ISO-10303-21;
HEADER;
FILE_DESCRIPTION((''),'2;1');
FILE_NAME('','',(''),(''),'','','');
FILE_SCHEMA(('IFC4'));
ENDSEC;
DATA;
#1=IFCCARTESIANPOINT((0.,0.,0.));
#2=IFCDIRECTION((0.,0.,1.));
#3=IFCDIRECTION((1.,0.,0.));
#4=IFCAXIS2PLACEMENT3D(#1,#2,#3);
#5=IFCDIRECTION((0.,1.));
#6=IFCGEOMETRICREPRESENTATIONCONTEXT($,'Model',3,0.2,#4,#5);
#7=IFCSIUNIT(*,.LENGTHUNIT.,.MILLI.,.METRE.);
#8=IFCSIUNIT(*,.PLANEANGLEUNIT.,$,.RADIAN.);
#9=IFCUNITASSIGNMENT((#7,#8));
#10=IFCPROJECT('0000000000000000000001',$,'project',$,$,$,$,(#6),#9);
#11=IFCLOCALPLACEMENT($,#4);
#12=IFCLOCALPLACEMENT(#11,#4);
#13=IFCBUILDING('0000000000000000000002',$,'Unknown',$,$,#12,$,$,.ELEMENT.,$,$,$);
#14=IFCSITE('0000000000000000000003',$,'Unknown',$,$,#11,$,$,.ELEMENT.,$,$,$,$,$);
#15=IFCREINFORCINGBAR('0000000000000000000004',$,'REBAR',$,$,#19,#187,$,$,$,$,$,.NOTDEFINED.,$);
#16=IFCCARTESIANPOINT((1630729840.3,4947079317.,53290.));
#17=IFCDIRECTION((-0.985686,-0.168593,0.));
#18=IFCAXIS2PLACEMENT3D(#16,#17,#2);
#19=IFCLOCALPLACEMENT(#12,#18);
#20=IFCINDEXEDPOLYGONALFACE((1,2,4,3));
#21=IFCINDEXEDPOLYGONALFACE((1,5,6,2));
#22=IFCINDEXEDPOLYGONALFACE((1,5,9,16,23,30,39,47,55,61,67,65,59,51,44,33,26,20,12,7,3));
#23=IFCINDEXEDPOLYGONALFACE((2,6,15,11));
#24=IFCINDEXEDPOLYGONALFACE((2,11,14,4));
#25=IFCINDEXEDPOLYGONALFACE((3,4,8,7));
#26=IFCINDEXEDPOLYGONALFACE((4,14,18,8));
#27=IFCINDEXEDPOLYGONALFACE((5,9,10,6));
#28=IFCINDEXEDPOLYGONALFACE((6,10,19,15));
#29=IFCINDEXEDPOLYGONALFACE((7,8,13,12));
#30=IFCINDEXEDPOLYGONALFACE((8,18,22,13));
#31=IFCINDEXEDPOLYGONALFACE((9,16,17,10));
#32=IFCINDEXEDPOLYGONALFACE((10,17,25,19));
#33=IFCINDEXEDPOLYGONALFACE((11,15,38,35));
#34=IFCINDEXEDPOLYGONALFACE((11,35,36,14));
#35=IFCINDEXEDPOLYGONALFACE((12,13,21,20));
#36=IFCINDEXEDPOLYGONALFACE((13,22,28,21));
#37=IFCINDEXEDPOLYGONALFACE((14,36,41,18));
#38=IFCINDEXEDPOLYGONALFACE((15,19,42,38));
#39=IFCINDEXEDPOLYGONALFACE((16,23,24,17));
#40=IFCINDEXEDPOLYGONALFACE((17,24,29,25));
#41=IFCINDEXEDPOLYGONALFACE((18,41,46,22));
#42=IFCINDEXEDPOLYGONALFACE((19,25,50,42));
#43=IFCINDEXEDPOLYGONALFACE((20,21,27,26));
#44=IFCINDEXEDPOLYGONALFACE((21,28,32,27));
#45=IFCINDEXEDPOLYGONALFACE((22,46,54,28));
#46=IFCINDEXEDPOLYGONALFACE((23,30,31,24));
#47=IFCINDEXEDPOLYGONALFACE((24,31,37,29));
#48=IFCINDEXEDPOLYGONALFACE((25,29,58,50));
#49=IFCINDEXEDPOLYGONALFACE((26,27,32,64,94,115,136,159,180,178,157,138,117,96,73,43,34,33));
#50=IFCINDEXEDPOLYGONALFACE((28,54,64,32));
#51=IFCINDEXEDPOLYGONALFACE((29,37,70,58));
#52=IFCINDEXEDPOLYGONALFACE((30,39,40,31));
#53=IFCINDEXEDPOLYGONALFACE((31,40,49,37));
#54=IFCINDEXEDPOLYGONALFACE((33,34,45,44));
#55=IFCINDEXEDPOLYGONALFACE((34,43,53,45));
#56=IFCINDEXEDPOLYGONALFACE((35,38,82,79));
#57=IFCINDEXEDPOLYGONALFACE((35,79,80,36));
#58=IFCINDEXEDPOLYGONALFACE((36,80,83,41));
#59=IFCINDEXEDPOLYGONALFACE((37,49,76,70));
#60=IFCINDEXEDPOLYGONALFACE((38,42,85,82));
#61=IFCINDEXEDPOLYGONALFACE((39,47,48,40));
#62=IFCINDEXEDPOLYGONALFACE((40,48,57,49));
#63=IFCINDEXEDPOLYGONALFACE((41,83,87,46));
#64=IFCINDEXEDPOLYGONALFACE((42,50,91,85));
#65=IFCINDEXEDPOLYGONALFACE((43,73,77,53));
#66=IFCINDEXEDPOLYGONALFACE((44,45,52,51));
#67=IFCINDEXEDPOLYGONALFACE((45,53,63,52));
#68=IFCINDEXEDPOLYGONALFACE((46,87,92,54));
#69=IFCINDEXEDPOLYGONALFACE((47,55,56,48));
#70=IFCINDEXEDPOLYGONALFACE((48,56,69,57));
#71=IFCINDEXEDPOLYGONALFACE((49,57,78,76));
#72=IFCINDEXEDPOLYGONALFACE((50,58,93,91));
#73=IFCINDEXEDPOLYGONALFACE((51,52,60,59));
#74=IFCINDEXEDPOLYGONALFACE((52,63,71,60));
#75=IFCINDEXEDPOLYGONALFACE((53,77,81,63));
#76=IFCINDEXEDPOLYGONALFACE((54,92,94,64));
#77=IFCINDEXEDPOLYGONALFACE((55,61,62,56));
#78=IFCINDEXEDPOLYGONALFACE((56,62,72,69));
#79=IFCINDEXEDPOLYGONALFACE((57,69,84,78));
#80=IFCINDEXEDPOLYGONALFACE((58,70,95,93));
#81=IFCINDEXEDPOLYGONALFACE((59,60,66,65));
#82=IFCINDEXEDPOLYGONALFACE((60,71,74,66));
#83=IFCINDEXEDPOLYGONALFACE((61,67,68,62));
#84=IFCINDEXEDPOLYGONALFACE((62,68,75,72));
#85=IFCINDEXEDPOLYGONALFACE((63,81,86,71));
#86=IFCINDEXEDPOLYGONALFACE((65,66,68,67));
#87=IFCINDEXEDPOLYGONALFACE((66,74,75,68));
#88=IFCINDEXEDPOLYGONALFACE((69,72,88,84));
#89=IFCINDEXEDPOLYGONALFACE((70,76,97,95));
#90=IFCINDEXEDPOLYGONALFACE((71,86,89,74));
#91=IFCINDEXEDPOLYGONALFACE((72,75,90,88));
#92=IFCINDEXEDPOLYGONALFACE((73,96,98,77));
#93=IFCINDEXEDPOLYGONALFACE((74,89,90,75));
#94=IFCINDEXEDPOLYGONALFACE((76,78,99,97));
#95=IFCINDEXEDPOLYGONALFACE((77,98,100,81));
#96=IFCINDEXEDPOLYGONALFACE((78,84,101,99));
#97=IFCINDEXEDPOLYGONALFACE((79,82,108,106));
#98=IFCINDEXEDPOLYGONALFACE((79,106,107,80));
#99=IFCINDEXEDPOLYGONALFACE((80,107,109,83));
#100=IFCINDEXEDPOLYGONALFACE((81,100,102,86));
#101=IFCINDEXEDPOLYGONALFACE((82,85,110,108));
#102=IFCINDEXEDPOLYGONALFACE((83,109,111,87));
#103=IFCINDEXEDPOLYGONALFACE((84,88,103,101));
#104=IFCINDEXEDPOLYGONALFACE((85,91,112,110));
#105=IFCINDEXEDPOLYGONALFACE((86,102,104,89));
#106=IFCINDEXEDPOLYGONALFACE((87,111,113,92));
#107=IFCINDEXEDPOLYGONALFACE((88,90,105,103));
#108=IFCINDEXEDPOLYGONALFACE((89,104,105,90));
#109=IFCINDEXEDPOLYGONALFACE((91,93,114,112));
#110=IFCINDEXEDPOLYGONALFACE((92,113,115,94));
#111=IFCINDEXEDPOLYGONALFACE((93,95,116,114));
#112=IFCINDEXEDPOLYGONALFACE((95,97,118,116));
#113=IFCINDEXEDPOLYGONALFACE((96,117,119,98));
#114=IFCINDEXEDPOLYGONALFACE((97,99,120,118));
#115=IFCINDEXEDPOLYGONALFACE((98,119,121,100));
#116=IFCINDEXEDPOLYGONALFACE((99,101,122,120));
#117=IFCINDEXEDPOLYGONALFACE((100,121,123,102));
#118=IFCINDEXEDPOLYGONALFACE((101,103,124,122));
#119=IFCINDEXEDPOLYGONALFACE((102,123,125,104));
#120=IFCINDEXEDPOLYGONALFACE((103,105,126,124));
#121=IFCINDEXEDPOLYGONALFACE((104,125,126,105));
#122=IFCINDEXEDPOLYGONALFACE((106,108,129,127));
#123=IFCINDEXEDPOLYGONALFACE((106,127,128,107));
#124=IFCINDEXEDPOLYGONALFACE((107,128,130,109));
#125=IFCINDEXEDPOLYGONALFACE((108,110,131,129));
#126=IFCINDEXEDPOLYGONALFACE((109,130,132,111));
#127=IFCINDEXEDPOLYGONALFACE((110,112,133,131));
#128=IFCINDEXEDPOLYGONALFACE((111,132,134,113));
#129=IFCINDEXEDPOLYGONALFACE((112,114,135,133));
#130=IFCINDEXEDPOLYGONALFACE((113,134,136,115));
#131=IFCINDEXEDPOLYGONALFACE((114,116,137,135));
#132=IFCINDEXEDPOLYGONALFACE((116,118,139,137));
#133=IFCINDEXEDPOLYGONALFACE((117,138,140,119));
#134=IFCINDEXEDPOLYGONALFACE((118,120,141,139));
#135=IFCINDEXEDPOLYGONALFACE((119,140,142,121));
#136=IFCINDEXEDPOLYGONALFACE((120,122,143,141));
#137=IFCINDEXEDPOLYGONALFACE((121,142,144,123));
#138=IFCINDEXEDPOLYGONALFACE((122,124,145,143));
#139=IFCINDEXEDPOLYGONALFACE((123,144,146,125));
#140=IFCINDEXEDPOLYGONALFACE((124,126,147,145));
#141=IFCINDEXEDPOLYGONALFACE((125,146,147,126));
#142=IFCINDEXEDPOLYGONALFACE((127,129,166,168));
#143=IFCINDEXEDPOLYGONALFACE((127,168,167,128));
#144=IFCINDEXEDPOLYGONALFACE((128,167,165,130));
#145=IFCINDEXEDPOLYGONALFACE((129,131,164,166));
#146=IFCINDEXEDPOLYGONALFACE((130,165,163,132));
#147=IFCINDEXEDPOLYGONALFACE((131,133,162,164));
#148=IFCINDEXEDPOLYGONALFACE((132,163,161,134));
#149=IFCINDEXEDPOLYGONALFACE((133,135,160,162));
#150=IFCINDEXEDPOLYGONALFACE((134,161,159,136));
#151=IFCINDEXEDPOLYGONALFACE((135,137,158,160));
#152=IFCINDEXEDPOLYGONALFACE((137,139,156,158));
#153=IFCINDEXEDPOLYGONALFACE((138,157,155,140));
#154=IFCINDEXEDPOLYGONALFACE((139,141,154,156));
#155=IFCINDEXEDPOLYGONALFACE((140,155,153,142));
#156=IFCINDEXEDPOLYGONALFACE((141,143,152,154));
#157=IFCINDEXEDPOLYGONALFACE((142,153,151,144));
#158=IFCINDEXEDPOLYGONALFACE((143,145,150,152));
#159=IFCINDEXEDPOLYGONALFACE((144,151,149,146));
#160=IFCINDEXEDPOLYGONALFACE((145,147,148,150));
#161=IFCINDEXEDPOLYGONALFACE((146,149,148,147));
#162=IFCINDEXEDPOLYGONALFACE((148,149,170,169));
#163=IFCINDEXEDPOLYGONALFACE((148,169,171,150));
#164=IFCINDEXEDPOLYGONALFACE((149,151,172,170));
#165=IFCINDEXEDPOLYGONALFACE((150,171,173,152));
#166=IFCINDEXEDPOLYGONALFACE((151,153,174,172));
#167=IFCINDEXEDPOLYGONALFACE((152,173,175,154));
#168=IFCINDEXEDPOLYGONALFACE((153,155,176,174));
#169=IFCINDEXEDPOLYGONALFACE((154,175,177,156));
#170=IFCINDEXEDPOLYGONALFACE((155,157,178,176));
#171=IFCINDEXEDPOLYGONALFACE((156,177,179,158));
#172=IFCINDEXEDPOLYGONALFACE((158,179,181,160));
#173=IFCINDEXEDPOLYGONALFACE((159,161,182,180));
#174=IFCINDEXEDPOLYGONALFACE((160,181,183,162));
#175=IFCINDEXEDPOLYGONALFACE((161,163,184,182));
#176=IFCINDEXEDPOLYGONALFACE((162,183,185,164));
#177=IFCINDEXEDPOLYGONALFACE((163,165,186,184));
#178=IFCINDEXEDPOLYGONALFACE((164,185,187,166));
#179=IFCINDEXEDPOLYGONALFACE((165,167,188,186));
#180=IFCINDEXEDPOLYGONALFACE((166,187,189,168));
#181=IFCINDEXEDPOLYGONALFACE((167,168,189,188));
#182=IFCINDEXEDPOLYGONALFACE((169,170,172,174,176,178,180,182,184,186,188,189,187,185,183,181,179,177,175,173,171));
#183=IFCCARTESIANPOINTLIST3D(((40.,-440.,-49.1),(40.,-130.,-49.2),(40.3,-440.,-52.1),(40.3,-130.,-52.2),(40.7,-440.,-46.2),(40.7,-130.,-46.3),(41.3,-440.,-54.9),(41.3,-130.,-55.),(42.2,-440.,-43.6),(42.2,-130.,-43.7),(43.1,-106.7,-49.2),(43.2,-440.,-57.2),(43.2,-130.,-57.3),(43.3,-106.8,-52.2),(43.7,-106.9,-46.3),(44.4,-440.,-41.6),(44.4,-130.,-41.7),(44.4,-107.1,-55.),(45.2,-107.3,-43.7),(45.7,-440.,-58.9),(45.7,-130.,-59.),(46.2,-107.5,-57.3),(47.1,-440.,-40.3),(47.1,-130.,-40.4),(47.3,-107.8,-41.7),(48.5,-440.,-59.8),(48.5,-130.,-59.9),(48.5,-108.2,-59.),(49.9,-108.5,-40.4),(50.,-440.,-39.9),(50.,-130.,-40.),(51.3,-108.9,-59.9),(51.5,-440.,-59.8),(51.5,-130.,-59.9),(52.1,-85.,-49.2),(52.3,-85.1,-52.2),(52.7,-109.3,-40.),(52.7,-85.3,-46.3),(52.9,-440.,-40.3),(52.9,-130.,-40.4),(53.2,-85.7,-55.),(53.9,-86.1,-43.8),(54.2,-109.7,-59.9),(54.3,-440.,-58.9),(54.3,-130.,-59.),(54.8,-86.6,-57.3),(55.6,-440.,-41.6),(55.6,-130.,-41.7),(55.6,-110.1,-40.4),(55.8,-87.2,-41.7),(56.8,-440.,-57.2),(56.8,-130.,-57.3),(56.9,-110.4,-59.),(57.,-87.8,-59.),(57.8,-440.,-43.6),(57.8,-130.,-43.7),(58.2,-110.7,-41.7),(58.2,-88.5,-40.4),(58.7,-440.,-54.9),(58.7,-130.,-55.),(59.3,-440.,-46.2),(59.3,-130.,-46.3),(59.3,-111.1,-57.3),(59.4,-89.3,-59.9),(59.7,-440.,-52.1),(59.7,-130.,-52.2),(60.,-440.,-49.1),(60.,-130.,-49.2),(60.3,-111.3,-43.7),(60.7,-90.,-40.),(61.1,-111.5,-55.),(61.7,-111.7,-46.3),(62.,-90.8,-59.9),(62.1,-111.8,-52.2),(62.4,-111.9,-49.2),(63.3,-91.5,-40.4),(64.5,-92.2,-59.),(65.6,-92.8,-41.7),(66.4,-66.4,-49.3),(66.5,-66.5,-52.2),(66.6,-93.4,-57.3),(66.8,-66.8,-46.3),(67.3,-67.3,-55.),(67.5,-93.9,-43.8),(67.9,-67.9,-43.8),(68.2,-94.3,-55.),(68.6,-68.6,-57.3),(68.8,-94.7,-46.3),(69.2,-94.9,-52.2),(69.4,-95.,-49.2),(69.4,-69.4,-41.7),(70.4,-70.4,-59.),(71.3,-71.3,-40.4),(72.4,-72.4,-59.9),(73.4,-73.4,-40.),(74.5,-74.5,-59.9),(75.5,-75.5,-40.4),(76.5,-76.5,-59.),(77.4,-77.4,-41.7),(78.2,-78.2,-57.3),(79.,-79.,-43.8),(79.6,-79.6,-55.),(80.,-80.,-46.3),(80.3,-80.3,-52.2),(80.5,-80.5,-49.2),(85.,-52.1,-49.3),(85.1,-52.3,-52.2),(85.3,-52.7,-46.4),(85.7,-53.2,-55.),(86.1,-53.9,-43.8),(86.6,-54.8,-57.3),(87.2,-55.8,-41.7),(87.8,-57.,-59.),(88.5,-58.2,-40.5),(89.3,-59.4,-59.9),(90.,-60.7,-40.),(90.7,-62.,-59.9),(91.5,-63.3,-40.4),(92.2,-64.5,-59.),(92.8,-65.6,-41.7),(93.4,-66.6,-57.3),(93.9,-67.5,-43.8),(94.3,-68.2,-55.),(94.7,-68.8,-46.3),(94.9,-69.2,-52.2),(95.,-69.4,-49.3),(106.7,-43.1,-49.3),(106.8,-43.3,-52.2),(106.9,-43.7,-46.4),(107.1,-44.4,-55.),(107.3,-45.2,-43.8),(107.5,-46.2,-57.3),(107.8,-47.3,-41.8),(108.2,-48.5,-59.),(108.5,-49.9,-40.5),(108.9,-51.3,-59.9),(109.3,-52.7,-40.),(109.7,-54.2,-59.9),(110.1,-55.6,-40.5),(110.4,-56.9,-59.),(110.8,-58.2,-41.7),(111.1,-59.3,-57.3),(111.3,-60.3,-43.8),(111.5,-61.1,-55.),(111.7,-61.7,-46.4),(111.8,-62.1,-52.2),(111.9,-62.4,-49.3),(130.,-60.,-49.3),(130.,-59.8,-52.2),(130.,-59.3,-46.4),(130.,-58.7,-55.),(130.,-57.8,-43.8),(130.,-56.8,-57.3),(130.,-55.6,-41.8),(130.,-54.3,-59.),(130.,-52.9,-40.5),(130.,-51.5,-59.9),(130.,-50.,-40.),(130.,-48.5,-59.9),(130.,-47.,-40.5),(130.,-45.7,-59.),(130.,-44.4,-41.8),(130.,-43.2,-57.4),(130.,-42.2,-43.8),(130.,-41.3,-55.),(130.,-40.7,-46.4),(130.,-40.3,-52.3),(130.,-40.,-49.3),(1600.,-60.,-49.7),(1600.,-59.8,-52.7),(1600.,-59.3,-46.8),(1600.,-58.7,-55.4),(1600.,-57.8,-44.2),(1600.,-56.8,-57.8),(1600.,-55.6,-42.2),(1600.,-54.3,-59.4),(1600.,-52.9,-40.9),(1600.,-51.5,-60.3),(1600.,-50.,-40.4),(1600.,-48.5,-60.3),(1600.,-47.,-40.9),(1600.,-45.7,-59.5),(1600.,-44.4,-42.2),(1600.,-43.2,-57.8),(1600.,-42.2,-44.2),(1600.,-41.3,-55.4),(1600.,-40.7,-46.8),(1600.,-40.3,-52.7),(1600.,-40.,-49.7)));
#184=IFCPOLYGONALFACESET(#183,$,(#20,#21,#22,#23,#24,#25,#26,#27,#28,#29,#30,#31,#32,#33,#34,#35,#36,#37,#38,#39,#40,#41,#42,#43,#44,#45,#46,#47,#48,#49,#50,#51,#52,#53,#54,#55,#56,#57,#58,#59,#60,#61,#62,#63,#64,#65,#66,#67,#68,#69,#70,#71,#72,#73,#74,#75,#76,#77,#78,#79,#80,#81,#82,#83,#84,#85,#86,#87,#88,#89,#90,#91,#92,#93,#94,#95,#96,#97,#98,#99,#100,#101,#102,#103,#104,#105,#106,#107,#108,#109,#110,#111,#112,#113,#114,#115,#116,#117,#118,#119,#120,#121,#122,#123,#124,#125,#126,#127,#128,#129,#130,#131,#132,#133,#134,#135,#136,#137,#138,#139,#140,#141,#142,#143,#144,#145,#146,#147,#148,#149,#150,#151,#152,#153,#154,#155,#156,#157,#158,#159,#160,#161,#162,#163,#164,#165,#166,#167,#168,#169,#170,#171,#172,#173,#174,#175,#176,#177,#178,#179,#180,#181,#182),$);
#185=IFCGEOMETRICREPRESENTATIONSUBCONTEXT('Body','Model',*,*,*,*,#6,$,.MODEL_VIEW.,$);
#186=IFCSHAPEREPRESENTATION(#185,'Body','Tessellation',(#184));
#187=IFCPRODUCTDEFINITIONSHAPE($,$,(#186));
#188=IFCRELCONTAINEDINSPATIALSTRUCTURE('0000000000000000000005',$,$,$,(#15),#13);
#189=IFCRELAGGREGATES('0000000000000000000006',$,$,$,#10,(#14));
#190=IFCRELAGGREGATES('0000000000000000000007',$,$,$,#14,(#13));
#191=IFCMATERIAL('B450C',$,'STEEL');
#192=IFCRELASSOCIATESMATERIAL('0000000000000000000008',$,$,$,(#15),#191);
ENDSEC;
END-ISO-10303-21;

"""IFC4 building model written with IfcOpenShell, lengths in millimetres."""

from ifc_helpers import new_model, entity, si_unit, direction, frame, origin_with_axes, place, context, subcontext, project, spatial, material, element, save


model = new_model("IFC4")

# Units and contexts
model_context = context("Model", 3, precision=0.2, world=origin_with_axes(), true_north=direction((0.0, 1.0)))
body_context = subcontext(model_context, "Body", "Model", "MODEL_VIEW")
ifc_project = project(units=[si_unit("LENGTHUNIT", "METRE", prefix="MILLI"), si_unit("PLANEANGLEUNIT", "RADIAN")], contexts=[model_context])

# Site, building
site_placement = place(None, origin_with_axes())
site = spatial("IfcSite", under=ifc_project, at=site_placement, Name="Unknown", CompositionType="ELEMENT")
building_placement = place(site_placement, origin_with_axes())
building = spatial("IfcBuilding", under=site, at=building_placement, Name="Unknown", CompositionType="ELEMENT")

# Reinforcing bar
ifc_material = material(Name="B450C", Category="STEEL")
reinforcing_bar_1_placement = place(building_placement, frame((1630729840.3, 4947079317.0, 53290.0), z_axis=(-0.985686, -0.168593, 0.0), x_axis=(0.0, 0.0, 1.0)))
element("IfcReinforcingBar", 1, at=reinforcing_bar_1_placement, inside=building, material=ifc_material, Name="REBAR", PredefinedType="NOTDEFINED", context=body_context, shape_type="AdvancedSweptSolid", body=[
    entity("IfcSweptDiskSolid", entity("IfcIndexedPolyCurve", entity("IfcCartesianPointList3D", [[50.0, -440.0, -49.9], [50.0, -130.0, -50.0], [73.4, -73.4, -50.0], [130.0, -50.0, -50.0], [1600.0, -50.0, -50.4]]), [entity("IfcLineIndex", [1, 2]), entity("IfcArcIndex", [2, 3, 4]), entity("IfcLineIndex", [4, 5])]), 10.0),
])

save(model, "model.ifc")
